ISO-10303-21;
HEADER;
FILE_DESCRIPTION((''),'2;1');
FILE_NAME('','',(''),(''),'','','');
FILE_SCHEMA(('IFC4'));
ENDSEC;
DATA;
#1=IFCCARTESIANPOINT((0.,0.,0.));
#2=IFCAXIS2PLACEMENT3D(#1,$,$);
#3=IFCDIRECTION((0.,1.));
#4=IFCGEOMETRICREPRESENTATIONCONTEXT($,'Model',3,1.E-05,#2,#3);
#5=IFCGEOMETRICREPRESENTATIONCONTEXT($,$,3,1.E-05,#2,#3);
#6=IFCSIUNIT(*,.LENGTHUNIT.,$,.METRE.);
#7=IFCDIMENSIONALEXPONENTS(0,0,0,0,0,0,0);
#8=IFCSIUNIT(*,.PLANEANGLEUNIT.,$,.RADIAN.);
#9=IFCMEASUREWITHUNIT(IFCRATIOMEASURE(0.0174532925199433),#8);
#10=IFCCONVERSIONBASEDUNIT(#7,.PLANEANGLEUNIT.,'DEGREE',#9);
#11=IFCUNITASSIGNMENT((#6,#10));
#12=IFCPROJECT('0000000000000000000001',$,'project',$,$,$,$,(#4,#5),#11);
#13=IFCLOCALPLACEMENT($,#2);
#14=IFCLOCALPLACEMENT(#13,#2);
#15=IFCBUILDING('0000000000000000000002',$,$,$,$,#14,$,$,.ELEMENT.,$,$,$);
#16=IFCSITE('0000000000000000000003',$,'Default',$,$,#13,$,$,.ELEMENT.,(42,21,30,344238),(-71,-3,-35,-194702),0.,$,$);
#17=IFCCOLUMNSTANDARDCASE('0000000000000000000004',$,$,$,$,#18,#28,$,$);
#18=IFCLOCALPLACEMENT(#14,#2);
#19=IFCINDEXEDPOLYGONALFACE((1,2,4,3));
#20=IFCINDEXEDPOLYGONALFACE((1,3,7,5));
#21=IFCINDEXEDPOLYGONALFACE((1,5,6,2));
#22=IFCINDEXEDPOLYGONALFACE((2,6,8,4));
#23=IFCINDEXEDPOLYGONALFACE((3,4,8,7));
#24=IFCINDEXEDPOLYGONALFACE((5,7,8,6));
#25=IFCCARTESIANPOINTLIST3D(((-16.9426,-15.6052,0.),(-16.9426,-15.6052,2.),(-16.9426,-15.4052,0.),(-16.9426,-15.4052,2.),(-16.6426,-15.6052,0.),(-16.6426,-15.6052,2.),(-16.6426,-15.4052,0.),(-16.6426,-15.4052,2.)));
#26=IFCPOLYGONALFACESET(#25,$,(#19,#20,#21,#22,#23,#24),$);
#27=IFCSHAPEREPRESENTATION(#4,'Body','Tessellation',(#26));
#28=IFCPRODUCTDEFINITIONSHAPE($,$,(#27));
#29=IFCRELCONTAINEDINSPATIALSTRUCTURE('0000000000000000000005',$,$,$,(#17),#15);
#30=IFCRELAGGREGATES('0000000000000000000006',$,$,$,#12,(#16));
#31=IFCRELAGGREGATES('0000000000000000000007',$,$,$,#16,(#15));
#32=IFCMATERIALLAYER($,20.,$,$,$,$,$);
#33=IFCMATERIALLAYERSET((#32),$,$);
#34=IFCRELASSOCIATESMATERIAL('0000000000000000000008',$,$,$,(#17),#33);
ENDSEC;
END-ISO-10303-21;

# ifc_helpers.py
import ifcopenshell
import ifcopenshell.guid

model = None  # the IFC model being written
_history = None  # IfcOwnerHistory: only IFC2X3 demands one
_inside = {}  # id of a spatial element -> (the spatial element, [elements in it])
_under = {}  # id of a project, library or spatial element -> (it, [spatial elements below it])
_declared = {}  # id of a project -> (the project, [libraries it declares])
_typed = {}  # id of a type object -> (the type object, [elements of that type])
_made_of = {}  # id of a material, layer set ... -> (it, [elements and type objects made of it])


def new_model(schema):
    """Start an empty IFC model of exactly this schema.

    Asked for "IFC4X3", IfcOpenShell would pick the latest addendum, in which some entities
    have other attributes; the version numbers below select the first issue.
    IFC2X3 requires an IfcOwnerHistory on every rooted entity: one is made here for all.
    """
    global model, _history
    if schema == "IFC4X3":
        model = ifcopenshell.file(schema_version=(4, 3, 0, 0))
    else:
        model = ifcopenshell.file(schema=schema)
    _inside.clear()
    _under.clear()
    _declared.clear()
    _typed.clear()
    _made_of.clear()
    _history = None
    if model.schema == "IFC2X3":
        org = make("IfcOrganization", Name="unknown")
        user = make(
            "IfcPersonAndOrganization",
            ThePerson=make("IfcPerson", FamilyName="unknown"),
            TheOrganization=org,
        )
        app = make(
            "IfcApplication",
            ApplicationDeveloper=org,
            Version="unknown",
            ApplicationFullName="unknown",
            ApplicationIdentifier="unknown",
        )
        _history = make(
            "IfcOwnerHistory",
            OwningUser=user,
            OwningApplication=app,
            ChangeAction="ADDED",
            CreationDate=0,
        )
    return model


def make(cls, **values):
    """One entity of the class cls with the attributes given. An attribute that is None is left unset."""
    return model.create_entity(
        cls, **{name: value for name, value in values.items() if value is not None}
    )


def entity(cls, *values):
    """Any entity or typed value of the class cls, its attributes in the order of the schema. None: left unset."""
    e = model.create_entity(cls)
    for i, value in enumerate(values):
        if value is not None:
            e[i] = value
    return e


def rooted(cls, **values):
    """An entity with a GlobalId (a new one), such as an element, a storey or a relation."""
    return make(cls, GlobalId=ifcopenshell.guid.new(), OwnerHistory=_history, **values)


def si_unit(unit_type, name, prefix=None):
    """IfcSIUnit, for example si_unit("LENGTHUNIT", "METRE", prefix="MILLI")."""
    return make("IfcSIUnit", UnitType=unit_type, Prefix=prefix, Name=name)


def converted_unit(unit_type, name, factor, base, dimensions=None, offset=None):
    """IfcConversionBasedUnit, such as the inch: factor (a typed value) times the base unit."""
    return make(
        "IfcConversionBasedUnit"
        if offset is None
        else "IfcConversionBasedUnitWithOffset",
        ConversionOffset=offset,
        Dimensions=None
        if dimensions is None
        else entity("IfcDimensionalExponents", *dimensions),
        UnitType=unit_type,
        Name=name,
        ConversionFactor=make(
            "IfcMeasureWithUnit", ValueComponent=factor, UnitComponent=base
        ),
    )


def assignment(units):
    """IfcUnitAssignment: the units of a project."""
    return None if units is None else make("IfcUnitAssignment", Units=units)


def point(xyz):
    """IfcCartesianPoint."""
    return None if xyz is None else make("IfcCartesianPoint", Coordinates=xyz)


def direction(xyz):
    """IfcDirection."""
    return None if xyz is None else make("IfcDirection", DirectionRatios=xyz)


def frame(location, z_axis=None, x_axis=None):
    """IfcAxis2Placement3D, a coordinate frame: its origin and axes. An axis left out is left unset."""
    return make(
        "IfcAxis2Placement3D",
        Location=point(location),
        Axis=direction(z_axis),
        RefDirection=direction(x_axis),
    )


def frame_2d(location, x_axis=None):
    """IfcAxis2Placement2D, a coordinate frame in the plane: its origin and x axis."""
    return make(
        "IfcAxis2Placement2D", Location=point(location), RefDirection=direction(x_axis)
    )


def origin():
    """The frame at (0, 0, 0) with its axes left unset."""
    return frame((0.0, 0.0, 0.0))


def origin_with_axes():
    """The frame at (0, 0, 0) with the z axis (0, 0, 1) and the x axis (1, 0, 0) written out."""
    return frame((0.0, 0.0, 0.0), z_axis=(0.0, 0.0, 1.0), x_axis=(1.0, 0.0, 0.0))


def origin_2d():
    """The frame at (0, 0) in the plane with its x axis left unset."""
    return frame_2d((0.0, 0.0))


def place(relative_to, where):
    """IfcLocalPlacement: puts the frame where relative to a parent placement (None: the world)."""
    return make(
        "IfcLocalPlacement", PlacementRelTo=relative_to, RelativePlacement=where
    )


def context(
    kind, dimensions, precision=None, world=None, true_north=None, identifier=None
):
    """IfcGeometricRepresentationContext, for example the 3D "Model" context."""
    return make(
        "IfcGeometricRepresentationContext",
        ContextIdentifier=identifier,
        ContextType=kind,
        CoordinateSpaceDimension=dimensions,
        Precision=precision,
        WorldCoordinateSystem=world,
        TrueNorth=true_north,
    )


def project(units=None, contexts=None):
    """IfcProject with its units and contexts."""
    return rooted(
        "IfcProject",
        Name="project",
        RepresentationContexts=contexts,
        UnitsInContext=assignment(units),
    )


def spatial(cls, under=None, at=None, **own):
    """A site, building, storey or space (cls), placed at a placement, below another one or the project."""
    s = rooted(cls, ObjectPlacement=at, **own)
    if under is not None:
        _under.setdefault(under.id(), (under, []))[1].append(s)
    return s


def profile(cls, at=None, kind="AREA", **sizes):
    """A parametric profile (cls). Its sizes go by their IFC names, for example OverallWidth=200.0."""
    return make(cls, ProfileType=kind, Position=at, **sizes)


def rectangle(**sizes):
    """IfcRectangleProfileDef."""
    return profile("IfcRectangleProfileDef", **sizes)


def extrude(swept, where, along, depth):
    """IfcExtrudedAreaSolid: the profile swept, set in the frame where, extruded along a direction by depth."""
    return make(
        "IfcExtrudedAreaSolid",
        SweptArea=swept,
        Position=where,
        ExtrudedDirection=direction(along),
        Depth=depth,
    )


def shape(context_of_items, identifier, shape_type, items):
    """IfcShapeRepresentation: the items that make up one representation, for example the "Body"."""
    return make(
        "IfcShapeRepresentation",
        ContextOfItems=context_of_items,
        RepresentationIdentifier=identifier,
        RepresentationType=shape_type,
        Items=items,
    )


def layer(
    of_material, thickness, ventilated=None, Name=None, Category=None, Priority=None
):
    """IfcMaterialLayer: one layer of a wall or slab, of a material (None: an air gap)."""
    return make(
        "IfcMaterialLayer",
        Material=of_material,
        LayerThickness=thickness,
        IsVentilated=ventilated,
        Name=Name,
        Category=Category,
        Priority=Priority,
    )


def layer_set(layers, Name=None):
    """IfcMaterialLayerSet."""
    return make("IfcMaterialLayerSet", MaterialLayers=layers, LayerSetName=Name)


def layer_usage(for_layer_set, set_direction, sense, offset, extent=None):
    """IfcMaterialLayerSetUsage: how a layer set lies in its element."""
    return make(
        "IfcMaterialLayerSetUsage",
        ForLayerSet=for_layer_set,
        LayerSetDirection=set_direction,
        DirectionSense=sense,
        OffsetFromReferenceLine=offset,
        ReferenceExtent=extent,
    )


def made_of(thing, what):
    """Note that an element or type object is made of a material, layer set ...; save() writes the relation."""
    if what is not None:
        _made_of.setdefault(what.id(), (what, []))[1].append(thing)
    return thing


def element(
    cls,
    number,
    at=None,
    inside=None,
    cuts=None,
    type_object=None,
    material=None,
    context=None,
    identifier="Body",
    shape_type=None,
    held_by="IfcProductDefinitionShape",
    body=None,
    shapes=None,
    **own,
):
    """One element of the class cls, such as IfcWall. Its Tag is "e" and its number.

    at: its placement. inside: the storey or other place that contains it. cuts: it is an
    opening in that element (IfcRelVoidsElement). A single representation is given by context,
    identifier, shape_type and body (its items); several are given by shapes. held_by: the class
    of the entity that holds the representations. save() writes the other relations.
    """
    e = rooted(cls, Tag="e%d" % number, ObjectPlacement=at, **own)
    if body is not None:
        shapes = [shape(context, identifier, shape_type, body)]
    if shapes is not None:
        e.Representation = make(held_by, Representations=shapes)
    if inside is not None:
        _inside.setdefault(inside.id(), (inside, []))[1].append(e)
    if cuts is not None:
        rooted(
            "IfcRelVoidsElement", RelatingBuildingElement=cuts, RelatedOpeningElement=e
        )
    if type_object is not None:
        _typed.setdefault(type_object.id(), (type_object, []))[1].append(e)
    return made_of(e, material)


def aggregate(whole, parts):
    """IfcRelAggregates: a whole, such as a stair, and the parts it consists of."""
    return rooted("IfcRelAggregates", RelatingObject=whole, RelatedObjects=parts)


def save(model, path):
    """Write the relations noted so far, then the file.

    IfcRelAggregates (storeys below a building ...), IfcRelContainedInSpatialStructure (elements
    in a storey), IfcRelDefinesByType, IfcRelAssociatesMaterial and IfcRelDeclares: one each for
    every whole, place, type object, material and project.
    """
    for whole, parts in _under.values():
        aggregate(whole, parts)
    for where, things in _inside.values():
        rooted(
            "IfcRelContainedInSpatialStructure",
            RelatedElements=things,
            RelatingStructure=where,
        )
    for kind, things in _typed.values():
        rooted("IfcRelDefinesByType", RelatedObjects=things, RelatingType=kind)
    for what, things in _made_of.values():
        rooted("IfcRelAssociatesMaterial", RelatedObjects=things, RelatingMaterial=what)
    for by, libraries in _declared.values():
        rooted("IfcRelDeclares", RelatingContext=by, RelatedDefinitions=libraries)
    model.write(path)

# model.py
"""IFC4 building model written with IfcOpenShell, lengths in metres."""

from ifc_helpers import new_model, entity, si_unit, converted_unit, direction, frame, origin, origin_with_axes, origin_2d, place, context, project, spatial, rectangle, extrude, layer, layer_set, layer_usage, element, save


model = new_model("IFC4")

# Units and contexts
model_context = context("Model", 3, precision=1e-05, world=origin(), true_north=direction((0.0, 1.0)))
context_of_model = context(None, 3, precision=1e-05, world=origin(), true_north=direction((0.0, 1.0)))
ifc_project = project(units=[si_unit("LENGTHUNIT", "METRE"), converted_unit("PLANEANGLEUNIT", "DEGREE", entity("IfcRatioMeasure", 0.0174532925199433), si_unit("PLANEANGLEUNIT", "RADIAN"), dimensions=[0, 0, 0, 0, 0, 0, 0])], contexts=[model_context, context_of_model])

# Site, building
site_placement = place(None, origin())
site = spatial("IfcSite", under=ifc_project, at=site_placement, Name="Default", CompositionType="ELEMENT", RefLatitude=(42, 21, 30, 344238), RefLongitude=(-71, -3, -35, -194702), RefElevation=0.0)
building_placement = place(site_placement, origin())
building = spatial("IfcBuilding", under=site, at=building_placement, CompositionType="ELEMENT")

# Column
ifc_layer_1 = layer(None, 20.0)
ifc_layer_set_1 = layer_set([ifc_layer_1])
ifc_layer_usage_1 = layer_usage(ifc_layer_set_1, "AXIS2", "POSITIVE", 150.0)
placement_1 = place(building_placement, origin())
placement_2 = place(placement_1, frame((-16.7926, -15.5052, 0.0), z_axis=(0.0, 0.0, 1.0), x_axis=(0.0, 1.0, 0.0)))
column_1_placement = place(placement_2, origin_with_axes())
element("IfcColumnStandardCase", 1, at=column_1_placement, inside=building, material=ifc_layer_usage_1, context=model_context, shape_type="SweptSolid", body=[
    extrude(rectangle(XDim=0.2, YDim=0.3, at=origin_2d()), origin(), (0.0, 0.0, 1.0), 2.0),
])

save(model, "model.ifc")
